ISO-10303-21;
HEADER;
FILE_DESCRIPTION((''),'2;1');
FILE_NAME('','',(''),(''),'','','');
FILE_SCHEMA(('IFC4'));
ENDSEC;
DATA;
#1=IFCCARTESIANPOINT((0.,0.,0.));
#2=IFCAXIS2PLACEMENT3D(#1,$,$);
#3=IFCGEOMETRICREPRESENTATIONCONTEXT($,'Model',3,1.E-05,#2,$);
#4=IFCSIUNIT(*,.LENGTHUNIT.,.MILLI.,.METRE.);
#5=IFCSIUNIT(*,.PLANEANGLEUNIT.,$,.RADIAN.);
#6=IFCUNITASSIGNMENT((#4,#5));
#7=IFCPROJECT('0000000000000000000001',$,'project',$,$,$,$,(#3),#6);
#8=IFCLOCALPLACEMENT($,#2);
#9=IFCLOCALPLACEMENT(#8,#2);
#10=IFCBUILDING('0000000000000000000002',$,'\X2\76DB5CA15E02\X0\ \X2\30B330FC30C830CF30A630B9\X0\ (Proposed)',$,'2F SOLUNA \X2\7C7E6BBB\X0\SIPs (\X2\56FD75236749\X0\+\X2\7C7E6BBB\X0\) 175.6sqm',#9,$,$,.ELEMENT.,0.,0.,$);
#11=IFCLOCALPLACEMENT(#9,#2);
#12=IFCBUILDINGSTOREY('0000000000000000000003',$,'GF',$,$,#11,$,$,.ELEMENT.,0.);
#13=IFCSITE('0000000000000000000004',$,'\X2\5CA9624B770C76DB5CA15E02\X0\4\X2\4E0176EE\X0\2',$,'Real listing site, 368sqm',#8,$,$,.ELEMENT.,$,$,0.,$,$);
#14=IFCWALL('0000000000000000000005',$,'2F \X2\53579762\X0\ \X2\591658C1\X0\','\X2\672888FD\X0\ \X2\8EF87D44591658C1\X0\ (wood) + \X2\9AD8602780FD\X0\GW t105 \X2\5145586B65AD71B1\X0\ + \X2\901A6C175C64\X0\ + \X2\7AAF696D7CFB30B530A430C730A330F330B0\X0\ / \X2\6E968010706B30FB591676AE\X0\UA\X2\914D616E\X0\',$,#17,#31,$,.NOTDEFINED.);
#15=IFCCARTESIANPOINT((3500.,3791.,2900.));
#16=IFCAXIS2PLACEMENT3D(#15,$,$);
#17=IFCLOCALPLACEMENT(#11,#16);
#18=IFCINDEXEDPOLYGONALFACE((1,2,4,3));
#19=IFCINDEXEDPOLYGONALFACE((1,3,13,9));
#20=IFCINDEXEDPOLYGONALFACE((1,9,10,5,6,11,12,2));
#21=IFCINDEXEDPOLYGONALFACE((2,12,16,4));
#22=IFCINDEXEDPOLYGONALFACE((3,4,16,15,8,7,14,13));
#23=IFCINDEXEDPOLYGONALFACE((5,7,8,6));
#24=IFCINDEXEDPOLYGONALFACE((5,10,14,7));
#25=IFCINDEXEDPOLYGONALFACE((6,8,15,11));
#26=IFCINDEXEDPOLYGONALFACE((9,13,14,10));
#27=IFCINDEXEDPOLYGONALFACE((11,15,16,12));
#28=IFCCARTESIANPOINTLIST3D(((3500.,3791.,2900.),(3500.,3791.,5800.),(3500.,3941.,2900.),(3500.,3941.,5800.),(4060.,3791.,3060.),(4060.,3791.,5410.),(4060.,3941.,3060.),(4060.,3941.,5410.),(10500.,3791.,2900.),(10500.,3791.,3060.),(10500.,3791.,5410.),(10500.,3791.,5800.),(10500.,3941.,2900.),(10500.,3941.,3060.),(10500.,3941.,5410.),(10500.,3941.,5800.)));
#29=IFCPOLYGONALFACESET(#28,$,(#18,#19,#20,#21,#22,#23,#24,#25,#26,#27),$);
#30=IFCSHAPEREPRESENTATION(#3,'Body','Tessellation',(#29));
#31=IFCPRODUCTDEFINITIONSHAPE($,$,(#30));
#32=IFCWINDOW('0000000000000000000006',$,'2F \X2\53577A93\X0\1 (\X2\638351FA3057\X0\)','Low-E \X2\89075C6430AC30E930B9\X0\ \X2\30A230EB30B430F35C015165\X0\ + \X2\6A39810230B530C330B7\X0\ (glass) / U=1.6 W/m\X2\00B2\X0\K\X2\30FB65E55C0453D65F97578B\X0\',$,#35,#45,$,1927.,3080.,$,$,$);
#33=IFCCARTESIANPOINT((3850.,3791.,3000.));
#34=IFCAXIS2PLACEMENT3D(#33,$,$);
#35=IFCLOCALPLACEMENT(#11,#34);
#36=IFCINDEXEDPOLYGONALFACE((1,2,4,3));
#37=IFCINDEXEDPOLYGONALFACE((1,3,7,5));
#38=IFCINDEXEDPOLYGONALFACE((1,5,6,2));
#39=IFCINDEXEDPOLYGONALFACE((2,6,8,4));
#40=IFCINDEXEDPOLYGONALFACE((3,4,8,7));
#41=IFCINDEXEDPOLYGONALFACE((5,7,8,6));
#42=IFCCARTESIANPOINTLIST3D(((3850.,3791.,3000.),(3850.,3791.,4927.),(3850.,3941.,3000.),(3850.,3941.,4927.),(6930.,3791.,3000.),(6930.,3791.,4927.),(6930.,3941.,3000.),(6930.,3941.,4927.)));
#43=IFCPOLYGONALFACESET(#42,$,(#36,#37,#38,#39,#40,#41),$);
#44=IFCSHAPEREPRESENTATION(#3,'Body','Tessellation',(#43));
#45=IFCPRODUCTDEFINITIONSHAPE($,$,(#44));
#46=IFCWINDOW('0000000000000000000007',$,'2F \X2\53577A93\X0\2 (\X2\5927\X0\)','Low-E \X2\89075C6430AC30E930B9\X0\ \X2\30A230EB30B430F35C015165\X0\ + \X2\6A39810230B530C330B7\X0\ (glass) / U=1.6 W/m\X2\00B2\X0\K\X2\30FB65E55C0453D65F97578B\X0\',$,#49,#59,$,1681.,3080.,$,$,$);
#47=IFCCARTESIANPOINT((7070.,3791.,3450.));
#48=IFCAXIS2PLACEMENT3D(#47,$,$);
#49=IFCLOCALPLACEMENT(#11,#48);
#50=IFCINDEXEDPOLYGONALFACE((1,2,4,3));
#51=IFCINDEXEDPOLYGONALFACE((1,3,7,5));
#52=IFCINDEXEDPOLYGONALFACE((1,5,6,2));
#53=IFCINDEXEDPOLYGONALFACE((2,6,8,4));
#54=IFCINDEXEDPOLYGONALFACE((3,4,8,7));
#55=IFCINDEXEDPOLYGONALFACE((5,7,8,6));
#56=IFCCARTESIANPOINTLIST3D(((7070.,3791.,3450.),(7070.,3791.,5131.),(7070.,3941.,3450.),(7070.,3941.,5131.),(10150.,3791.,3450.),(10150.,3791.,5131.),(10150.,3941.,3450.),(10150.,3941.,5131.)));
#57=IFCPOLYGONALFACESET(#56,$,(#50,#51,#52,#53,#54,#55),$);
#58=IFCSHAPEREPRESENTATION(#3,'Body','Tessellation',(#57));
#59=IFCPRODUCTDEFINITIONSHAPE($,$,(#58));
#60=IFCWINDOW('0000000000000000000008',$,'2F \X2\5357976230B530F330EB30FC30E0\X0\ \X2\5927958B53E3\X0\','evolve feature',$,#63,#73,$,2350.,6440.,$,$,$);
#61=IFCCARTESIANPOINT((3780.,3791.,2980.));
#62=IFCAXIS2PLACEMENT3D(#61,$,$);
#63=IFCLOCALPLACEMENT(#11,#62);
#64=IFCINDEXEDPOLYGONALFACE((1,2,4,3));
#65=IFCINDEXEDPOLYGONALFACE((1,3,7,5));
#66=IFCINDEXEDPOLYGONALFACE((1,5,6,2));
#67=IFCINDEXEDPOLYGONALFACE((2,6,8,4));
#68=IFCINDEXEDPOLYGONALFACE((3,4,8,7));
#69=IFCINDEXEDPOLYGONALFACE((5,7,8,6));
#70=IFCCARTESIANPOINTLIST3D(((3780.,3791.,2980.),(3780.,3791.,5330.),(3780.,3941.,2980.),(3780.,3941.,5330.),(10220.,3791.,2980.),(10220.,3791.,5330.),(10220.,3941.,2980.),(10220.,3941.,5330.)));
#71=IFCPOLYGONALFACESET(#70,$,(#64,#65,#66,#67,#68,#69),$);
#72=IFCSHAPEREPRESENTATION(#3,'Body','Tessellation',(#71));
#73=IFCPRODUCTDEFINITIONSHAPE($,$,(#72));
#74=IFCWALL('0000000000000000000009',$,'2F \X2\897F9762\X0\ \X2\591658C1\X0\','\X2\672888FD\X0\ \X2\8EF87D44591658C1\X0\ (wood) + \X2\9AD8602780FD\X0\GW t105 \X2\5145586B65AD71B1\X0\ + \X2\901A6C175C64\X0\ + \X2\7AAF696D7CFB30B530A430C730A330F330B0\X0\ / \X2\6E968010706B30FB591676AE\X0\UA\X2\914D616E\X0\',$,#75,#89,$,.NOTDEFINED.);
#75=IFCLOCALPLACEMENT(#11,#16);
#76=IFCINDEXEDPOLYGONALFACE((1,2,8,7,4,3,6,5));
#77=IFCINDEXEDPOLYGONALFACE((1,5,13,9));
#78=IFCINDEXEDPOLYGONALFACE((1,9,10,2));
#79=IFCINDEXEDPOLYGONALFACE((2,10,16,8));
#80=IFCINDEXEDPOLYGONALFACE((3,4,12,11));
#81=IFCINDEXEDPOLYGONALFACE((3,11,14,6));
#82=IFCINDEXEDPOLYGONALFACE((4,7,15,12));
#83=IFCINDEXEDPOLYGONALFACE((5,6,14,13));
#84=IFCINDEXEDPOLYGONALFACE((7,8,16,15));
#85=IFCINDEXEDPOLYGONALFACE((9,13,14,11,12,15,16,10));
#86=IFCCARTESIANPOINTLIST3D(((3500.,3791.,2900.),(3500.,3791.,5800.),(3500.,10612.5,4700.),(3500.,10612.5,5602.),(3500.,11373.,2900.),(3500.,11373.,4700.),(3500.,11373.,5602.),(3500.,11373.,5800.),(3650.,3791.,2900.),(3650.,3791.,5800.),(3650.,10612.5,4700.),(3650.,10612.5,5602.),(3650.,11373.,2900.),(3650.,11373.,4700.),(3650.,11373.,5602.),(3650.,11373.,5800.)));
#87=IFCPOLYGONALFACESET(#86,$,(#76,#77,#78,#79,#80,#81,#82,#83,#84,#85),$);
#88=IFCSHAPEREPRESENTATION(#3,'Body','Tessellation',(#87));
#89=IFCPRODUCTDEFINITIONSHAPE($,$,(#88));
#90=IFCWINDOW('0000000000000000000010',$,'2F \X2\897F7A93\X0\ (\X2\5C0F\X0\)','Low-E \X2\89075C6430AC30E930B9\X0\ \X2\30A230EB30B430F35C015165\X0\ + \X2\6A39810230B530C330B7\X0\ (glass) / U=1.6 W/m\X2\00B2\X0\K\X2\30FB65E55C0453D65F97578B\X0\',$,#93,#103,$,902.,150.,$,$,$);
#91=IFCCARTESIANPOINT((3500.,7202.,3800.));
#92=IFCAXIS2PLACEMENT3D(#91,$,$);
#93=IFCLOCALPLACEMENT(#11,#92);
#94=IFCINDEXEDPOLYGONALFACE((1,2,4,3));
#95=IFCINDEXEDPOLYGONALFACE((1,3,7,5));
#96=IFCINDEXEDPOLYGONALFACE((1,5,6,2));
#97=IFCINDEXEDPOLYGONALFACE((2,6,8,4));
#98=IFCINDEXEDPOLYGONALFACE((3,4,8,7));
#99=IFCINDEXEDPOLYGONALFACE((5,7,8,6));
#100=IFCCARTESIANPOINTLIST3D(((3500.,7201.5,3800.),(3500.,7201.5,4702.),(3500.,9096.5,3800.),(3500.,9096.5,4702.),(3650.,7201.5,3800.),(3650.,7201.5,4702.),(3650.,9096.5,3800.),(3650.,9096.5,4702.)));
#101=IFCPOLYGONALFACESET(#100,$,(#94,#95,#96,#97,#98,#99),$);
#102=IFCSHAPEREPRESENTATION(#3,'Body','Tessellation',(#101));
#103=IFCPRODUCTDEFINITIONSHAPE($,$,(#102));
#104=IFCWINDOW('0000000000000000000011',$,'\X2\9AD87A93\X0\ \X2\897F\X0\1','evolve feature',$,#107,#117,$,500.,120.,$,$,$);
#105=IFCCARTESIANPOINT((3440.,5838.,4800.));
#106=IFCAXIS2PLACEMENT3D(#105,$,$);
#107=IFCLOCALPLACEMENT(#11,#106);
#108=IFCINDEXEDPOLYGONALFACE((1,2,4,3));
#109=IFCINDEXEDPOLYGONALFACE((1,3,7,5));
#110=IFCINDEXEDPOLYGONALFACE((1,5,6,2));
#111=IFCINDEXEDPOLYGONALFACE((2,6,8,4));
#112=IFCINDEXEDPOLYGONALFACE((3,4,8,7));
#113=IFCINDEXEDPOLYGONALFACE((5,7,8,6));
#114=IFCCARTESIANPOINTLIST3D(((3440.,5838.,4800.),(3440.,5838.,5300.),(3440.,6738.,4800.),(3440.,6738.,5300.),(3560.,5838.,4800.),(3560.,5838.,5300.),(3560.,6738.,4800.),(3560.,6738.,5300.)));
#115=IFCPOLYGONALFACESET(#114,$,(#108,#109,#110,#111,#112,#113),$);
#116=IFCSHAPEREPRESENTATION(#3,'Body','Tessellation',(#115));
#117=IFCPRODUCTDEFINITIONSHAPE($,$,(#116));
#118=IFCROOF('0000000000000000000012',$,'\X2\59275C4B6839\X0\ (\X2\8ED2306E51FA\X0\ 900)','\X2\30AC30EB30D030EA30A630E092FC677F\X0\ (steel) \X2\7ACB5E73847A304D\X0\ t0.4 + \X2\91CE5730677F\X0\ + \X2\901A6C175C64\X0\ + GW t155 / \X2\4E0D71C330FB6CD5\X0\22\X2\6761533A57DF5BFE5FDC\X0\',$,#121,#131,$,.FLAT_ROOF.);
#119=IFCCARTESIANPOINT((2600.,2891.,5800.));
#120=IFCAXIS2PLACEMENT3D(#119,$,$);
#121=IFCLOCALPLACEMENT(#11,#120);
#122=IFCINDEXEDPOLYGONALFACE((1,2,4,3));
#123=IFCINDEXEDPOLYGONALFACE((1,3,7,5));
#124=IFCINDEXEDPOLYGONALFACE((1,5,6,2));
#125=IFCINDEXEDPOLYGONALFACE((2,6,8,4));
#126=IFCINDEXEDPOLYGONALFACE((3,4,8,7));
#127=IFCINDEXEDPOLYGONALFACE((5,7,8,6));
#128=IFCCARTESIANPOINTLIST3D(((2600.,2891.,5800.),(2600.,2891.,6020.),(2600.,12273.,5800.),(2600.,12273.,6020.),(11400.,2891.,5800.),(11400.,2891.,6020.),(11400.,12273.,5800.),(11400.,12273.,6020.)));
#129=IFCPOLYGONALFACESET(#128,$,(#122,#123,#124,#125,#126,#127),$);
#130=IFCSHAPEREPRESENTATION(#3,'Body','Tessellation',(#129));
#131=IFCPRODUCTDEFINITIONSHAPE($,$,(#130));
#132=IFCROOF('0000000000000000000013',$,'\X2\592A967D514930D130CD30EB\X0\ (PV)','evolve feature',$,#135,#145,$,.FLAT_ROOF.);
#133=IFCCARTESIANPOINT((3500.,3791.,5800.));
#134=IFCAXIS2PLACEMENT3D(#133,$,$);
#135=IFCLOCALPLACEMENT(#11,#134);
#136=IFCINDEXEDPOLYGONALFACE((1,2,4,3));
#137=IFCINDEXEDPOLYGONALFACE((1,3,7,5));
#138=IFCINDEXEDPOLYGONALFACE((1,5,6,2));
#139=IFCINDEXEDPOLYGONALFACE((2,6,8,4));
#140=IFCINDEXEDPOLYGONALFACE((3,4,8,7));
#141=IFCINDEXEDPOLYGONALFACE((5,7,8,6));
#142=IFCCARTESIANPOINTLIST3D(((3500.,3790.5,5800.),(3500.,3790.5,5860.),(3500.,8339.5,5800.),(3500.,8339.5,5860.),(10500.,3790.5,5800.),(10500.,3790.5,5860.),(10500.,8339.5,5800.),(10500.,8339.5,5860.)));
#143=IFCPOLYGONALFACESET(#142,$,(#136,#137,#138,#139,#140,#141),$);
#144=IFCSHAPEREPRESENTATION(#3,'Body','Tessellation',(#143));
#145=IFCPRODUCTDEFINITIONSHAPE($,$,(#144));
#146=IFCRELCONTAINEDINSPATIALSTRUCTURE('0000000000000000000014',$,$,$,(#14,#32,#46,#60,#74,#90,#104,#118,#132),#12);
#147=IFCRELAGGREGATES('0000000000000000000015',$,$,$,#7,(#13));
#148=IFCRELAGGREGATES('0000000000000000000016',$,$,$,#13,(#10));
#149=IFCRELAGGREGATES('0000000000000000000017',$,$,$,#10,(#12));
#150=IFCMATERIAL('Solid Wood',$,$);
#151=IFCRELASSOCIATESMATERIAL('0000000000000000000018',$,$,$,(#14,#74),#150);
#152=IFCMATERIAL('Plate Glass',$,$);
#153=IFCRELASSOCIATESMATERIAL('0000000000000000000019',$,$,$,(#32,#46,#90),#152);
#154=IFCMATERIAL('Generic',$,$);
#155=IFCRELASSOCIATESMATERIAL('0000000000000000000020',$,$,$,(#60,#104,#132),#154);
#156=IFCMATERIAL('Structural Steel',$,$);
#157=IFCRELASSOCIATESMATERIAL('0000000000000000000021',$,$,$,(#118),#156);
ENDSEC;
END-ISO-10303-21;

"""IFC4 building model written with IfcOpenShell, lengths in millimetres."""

from ifc_helpers import new_model, si_unit, frame, frame_2d, origin, place, context, project, spatial, rectangle, extrude, material, element, fill, save


model = new_model("IFC4")

# Units and contexts
model_context = context("Model", 3, precision=1e-05, world=origin())
ifc_project = project(units=[si_unit("LENGTHUNIT", "METRE", prefix="MILLI"), si_unit("PLANEANGLEUNIT", "RADIAN")], contexts=[model_context])

# Site, building, storey
site_placement = place(None, origin())
site = spatial("IfcSite", under=ifc_project, at=site_placement, Name="岩手県盛岡市4丁目2", ObjectType="Real listing site, 368sqm", CompositionType="ELEMENT", RefElevation=0.0)
building_placement = place(site_placement, origin())
building = spatial("IfcBuilding", under=site, at=building_placement, Name="盛岡市 コートハウス (Proposed)", ObjectType="2F SOLUNA 籾殻SIPs (国産杉+籾殻) 175.6sqm", CompositionType="ELEMENT", ElevationOfRefHeight=0.0, ElevationOfTerrain=0.0)
storey_placement = place(building_placement, origin())
storey = spatial("IfcBuildingStorey", under=building, at=storey_placement, Name="GF", CompositionType="ELEMENT", Elevation=0.0)

# Shared definitions
ifc_material_1 = material(Name="Solid Wood")
ifc_material_2 = material(Name="Generic")

# Shared definitions
ifc_material_3 = material(Name="Plate Glass")

# Walls, openings, windows
wall_1_placement = place(storey_placement, frame((3500.0, 3791.0, 2900.0)))
wall_1 = element("IfcWall", 1, at=wall_1_placement, inside=storey, material=ifc_material_1, Name="2F 南面 外壁", Description="木製 軸組外壁 (wood) + 高性能GW t105 充填断熱 + 通気層 + 窯業系サイディング / 準耐火・外皮UA配慮", PredefinedType="NOTDEFINED", context=model_context, shape_type="SweptSolid", body=[
    extrude(rectangle(XDim=7000.0, YDim=150.0, at=frame_2d((3500.0, 75.0))), frame((3500.0, 3791.0, 2900.0)), (0.0, 0.0, 1.0), 2900.0),
])
opening_1_placement = place(storey_placement, frame((3850.0, 3791.0, 3000.0)))
opening_1 = element("IfcOpeningElement", 2, at=opening_1_placement, cuts=wall_1, PredefinedType="NOTDEFINED", context=model_context, shape_type="SweptSolid", body=[
    extrude(rectangle(XDim=3080.0, YDim=150.0, at=frame_2d((1540.0, 75.0))), frame((3850.0, 3791.0, 3000.0)), (0.0, 0.0, 1.0), 1927.0),
])
opening_2_placement = place(storey_placement, frame((7070.0, 3791.0, 3450.0)))
opening_2 = element("IfcOpeningElement", 3, at=opening_2_placement, cuts=wall_1, PredefinedType="NOTDEFINED", context=model_context, shape_type="SweptSolid", body=[
    extrude(rectangle(XDim=3080.0, YDim=150.0, at=frame_2d((1540.0, 75.0))), frame((7070.0, 3791.0, 3450.0)), (0.0, 0.0, 1.0), 1681.0),
])
opening_3_placement = place(storey_placement, frame((3780.0, 3791.0, 2980.0)))
opening_3 = element("IfcOpeningElement", 4, at=opening_3_placement, cuts=wall_1, PredefinedType="NOTDEFINED", context=model_context, shape_type="SweptSolid", body=[
    extrude(rectangle(XDim=6440.0, YDim=150.0, at=frame_2d((3220.0, 75.0))), frame((3780.0, 3791.0, 2980.0)), (0.0, 0.0, 1.0), 2350.0),
])
window_1_placement = place(storey_placement, frame((3850.0, 3791.0, 3000.0)))
window_1 = element("IfcWindow", 5, at=window_1_placement, inside=storey, material=ifc_material_3, Name="2F 南窓1 (掃出し)", Description="Low-E 複層ガラス アルゴン封入 + 樹脂サッシ (glass) / U=1.6 W/m²K・日射取得型", OverallHeight=1927.0, OverallWidth=3080.0, context=model_context, shape_type="SweptSolid", body=[
    extrude(rectangle(XDim=3080.0, YDim=150.0, at=frame_2d((1540.0, 75.0))), frame((3850.0, 3791.0, 3000.0)), (0.0, 0.0, 1.0), 1927.0),
])
fill(opening_1, window_1)
window_2_placement = place(storey_placement, frame((7070.0, 3791.0, 3450.0)))
window_2 = element("IfcWindow", 6, at=window_2_placement, inside=storey, material=ifc_material_3, Name="2F 南窓2 (大)", Description="Low-E 複層ガラス アルゴン封入 + 樹脂サッシ (glass) / U=1.6 W/m²K・日射取得型", OverallHeight=1681.0, OverallWidth=3080.0, context=model_context, shape_type="SweptSolid", body=[
    extrude(rectangle(XDim=3080.0, YDim=150.0, at=frame_2d((1540.0, 75.0))), frame((7070.0, 3791.0, 3450.0)), (0.0, 0.0, 1.0), 1681.0),
])
fill(opening_2, window_2)
window_3_placement = place(storey_placement, frame((3780.0, 3791.0, 2980.0)))
window_3 = element("IfcWindow", 7, at=window_3_placement, inside=storey, material=ifc_material_2, Name="2F 南面サンルーム 大開口", Description="evolve feature", OverallHeight=2350.0, OverallWidth=6440.0, context=model_context, shape_type="SweptSolid", body=[
    extrude(rectangle(XDim=6440.0, YDim=150.0, at=frame_2d((3220.0, 75.0))), frame((3780.0, 3791.0, 2980.0)), (0.0, 0.0, 1.0), 2350.0),
])
fill(opening_3, window_3)
wall_2_placement = place(storey_placement, frame((3500.0, 3791.0, 2900.0)))
wall_2 = element("IfcWall", 8, at=wall_2_placement, inside=storey, material=ifc_material_1, Name="2F 西面 外壁", Description="木製 軸組外壁 (wood) + 高性能GW t105 充填断熱 + 通気層 + 窯業系サイディング / 準耐火・外皮UA配慮", PredefinedType="NOTDEFINED", context=model_context, shape_type="SweptSolid", body=[
    extrude(rectangle(XDim=150.0, YDim=7582.0, at=frame_2d((75.0, 3791.0))), frame((3500.0, 3791.0, 2900.0)), (0.0, 0.0, 1.0), 2900.0),
])
opening_4_placement = place(storey_placement, frame((3500.0, 7202.0, 3800.0)))
opening_4 = element("IfcOpeningElement", 9, at=opening_4_placement, cuts=wall_2, PredefinedType="NOTDEFINED", context=model_context, shape_type="SweptSolid", body=[
    extrude(rectangle(XDim=150.0, YDim=1895.0, at=frame_2d((75.0, 947.0))), frame((3500.0, 7202.0, 3800.0)), (0.0, 0.0, 1.0), 902.0),
])
opening_5_placement = place(storey_placement, frame((3440.0, 5838.0, 4800.0)))
opening_5 = element("IfcOpeningElement", 10, at=opening_5_placement, cuts=wall_2, PredefinedType="NOTDEFINED", context=model_context, shape_type="SweptSolid", body=[
    extrude(rectangle(XDim=120.0, YDim=900.0, at=frame_2d((60.0, 450.0))), frame((3440.0, 5838.0, 4800.0)), (0.0, 0.0, 1.0), 500.0),
])
window_4_placement = place(storey_placement, frame((3500.0, 7202.0, 3800.0)))
window_4 = element("IfcWindow", 11, at=window_4_placement, inside=storey, material=ifc_material_3, Name="2F 西窓 (小)", Description="Low-E 複層ガラス アルゴン封入 + 樹脂サッシ (glass) / U=1.6 W/m²K・日射取得型", OverallHeight=902.0, OverallWidth=150.0, context=model_context, shape_type="SweptSolid", body=[
    extrude(rectangle(XDim=150.0, YDim=1895.0, at=frame_2d((75.0, 947.0))), frame((3500.0, 7202.0, 3800.0)), (0.0, 0.0, 1.0), 902.0),
])
fill(opening_4, window_4)
window_5_placement = place(storey_placement, frame((3440.0, 5838.0, 4800.0)))
window_5 = element("IfcWindow", 12, at=window_5_placement, inside=storey, material=ifc_material_2, Name="高窓 西1", Description="evolve feature", OverallHeight=500.0, OverallWidth=120.0, context=model_context, shape_type="SweptSolid", body=[
    extrude(rectangle(XDim=120.0, YDim=900.0, at=frame_2d((60.0, 450.0))), frame((3440.0, 5838.0, 4800.0)), (0.0, 0.0, 1.0), 500.0),
])
fill(opening_5, window_5)

# Roofs
ifc_material_4 = material(Name="Structural Steel")
roof_1_placement = place(storey_placement, frame((2600.0, 2891.0, 5800.0)))
element("IfcRoof", 13, at=roof_1_placement, inside=storey, material=ifc_material_4, Name="大屋根 (軒の出 900)", Description="ガルバリウム鋼板 (steel) 立平葺き t0.4 + 野地板 + 通気層 + GW t155 / 不燃・法22条区域対応", PredefinedType="FLAT_ROOF", context=model_context, shape_type="SweptSolid", body=[
    extrude(rectangle(XDim=8800.0, YDim=9382.0, at=frame_2d((4400.0, 4691.0))), frame((2600.0, 2891.0, 5800.0)), (0.0, 0.0, 1.0), 220.0),
])
roof_2_placement = place(storey_placement, frame((3500.0, 3791.0, 5800.0)))
element("IfcRoof", 14, at=roof_2_placement, inside=storey, material=ifc_material_2, Name="太陽光パネル (PV)", Description="evolve feature", PredefinedType="FLAT_ROOF", context=model_context, shape_type="SweptSolid", body=[
    extrude(rectangle(XDim=7000.0, YDim=4549.0, at=frame_2d((3500.0, 2274.0))), frame((3500.0, 3791.0, 5800.0)), (0.0, 0.0, 1.0), 60.0),
])

save(model, "model.ifc")
